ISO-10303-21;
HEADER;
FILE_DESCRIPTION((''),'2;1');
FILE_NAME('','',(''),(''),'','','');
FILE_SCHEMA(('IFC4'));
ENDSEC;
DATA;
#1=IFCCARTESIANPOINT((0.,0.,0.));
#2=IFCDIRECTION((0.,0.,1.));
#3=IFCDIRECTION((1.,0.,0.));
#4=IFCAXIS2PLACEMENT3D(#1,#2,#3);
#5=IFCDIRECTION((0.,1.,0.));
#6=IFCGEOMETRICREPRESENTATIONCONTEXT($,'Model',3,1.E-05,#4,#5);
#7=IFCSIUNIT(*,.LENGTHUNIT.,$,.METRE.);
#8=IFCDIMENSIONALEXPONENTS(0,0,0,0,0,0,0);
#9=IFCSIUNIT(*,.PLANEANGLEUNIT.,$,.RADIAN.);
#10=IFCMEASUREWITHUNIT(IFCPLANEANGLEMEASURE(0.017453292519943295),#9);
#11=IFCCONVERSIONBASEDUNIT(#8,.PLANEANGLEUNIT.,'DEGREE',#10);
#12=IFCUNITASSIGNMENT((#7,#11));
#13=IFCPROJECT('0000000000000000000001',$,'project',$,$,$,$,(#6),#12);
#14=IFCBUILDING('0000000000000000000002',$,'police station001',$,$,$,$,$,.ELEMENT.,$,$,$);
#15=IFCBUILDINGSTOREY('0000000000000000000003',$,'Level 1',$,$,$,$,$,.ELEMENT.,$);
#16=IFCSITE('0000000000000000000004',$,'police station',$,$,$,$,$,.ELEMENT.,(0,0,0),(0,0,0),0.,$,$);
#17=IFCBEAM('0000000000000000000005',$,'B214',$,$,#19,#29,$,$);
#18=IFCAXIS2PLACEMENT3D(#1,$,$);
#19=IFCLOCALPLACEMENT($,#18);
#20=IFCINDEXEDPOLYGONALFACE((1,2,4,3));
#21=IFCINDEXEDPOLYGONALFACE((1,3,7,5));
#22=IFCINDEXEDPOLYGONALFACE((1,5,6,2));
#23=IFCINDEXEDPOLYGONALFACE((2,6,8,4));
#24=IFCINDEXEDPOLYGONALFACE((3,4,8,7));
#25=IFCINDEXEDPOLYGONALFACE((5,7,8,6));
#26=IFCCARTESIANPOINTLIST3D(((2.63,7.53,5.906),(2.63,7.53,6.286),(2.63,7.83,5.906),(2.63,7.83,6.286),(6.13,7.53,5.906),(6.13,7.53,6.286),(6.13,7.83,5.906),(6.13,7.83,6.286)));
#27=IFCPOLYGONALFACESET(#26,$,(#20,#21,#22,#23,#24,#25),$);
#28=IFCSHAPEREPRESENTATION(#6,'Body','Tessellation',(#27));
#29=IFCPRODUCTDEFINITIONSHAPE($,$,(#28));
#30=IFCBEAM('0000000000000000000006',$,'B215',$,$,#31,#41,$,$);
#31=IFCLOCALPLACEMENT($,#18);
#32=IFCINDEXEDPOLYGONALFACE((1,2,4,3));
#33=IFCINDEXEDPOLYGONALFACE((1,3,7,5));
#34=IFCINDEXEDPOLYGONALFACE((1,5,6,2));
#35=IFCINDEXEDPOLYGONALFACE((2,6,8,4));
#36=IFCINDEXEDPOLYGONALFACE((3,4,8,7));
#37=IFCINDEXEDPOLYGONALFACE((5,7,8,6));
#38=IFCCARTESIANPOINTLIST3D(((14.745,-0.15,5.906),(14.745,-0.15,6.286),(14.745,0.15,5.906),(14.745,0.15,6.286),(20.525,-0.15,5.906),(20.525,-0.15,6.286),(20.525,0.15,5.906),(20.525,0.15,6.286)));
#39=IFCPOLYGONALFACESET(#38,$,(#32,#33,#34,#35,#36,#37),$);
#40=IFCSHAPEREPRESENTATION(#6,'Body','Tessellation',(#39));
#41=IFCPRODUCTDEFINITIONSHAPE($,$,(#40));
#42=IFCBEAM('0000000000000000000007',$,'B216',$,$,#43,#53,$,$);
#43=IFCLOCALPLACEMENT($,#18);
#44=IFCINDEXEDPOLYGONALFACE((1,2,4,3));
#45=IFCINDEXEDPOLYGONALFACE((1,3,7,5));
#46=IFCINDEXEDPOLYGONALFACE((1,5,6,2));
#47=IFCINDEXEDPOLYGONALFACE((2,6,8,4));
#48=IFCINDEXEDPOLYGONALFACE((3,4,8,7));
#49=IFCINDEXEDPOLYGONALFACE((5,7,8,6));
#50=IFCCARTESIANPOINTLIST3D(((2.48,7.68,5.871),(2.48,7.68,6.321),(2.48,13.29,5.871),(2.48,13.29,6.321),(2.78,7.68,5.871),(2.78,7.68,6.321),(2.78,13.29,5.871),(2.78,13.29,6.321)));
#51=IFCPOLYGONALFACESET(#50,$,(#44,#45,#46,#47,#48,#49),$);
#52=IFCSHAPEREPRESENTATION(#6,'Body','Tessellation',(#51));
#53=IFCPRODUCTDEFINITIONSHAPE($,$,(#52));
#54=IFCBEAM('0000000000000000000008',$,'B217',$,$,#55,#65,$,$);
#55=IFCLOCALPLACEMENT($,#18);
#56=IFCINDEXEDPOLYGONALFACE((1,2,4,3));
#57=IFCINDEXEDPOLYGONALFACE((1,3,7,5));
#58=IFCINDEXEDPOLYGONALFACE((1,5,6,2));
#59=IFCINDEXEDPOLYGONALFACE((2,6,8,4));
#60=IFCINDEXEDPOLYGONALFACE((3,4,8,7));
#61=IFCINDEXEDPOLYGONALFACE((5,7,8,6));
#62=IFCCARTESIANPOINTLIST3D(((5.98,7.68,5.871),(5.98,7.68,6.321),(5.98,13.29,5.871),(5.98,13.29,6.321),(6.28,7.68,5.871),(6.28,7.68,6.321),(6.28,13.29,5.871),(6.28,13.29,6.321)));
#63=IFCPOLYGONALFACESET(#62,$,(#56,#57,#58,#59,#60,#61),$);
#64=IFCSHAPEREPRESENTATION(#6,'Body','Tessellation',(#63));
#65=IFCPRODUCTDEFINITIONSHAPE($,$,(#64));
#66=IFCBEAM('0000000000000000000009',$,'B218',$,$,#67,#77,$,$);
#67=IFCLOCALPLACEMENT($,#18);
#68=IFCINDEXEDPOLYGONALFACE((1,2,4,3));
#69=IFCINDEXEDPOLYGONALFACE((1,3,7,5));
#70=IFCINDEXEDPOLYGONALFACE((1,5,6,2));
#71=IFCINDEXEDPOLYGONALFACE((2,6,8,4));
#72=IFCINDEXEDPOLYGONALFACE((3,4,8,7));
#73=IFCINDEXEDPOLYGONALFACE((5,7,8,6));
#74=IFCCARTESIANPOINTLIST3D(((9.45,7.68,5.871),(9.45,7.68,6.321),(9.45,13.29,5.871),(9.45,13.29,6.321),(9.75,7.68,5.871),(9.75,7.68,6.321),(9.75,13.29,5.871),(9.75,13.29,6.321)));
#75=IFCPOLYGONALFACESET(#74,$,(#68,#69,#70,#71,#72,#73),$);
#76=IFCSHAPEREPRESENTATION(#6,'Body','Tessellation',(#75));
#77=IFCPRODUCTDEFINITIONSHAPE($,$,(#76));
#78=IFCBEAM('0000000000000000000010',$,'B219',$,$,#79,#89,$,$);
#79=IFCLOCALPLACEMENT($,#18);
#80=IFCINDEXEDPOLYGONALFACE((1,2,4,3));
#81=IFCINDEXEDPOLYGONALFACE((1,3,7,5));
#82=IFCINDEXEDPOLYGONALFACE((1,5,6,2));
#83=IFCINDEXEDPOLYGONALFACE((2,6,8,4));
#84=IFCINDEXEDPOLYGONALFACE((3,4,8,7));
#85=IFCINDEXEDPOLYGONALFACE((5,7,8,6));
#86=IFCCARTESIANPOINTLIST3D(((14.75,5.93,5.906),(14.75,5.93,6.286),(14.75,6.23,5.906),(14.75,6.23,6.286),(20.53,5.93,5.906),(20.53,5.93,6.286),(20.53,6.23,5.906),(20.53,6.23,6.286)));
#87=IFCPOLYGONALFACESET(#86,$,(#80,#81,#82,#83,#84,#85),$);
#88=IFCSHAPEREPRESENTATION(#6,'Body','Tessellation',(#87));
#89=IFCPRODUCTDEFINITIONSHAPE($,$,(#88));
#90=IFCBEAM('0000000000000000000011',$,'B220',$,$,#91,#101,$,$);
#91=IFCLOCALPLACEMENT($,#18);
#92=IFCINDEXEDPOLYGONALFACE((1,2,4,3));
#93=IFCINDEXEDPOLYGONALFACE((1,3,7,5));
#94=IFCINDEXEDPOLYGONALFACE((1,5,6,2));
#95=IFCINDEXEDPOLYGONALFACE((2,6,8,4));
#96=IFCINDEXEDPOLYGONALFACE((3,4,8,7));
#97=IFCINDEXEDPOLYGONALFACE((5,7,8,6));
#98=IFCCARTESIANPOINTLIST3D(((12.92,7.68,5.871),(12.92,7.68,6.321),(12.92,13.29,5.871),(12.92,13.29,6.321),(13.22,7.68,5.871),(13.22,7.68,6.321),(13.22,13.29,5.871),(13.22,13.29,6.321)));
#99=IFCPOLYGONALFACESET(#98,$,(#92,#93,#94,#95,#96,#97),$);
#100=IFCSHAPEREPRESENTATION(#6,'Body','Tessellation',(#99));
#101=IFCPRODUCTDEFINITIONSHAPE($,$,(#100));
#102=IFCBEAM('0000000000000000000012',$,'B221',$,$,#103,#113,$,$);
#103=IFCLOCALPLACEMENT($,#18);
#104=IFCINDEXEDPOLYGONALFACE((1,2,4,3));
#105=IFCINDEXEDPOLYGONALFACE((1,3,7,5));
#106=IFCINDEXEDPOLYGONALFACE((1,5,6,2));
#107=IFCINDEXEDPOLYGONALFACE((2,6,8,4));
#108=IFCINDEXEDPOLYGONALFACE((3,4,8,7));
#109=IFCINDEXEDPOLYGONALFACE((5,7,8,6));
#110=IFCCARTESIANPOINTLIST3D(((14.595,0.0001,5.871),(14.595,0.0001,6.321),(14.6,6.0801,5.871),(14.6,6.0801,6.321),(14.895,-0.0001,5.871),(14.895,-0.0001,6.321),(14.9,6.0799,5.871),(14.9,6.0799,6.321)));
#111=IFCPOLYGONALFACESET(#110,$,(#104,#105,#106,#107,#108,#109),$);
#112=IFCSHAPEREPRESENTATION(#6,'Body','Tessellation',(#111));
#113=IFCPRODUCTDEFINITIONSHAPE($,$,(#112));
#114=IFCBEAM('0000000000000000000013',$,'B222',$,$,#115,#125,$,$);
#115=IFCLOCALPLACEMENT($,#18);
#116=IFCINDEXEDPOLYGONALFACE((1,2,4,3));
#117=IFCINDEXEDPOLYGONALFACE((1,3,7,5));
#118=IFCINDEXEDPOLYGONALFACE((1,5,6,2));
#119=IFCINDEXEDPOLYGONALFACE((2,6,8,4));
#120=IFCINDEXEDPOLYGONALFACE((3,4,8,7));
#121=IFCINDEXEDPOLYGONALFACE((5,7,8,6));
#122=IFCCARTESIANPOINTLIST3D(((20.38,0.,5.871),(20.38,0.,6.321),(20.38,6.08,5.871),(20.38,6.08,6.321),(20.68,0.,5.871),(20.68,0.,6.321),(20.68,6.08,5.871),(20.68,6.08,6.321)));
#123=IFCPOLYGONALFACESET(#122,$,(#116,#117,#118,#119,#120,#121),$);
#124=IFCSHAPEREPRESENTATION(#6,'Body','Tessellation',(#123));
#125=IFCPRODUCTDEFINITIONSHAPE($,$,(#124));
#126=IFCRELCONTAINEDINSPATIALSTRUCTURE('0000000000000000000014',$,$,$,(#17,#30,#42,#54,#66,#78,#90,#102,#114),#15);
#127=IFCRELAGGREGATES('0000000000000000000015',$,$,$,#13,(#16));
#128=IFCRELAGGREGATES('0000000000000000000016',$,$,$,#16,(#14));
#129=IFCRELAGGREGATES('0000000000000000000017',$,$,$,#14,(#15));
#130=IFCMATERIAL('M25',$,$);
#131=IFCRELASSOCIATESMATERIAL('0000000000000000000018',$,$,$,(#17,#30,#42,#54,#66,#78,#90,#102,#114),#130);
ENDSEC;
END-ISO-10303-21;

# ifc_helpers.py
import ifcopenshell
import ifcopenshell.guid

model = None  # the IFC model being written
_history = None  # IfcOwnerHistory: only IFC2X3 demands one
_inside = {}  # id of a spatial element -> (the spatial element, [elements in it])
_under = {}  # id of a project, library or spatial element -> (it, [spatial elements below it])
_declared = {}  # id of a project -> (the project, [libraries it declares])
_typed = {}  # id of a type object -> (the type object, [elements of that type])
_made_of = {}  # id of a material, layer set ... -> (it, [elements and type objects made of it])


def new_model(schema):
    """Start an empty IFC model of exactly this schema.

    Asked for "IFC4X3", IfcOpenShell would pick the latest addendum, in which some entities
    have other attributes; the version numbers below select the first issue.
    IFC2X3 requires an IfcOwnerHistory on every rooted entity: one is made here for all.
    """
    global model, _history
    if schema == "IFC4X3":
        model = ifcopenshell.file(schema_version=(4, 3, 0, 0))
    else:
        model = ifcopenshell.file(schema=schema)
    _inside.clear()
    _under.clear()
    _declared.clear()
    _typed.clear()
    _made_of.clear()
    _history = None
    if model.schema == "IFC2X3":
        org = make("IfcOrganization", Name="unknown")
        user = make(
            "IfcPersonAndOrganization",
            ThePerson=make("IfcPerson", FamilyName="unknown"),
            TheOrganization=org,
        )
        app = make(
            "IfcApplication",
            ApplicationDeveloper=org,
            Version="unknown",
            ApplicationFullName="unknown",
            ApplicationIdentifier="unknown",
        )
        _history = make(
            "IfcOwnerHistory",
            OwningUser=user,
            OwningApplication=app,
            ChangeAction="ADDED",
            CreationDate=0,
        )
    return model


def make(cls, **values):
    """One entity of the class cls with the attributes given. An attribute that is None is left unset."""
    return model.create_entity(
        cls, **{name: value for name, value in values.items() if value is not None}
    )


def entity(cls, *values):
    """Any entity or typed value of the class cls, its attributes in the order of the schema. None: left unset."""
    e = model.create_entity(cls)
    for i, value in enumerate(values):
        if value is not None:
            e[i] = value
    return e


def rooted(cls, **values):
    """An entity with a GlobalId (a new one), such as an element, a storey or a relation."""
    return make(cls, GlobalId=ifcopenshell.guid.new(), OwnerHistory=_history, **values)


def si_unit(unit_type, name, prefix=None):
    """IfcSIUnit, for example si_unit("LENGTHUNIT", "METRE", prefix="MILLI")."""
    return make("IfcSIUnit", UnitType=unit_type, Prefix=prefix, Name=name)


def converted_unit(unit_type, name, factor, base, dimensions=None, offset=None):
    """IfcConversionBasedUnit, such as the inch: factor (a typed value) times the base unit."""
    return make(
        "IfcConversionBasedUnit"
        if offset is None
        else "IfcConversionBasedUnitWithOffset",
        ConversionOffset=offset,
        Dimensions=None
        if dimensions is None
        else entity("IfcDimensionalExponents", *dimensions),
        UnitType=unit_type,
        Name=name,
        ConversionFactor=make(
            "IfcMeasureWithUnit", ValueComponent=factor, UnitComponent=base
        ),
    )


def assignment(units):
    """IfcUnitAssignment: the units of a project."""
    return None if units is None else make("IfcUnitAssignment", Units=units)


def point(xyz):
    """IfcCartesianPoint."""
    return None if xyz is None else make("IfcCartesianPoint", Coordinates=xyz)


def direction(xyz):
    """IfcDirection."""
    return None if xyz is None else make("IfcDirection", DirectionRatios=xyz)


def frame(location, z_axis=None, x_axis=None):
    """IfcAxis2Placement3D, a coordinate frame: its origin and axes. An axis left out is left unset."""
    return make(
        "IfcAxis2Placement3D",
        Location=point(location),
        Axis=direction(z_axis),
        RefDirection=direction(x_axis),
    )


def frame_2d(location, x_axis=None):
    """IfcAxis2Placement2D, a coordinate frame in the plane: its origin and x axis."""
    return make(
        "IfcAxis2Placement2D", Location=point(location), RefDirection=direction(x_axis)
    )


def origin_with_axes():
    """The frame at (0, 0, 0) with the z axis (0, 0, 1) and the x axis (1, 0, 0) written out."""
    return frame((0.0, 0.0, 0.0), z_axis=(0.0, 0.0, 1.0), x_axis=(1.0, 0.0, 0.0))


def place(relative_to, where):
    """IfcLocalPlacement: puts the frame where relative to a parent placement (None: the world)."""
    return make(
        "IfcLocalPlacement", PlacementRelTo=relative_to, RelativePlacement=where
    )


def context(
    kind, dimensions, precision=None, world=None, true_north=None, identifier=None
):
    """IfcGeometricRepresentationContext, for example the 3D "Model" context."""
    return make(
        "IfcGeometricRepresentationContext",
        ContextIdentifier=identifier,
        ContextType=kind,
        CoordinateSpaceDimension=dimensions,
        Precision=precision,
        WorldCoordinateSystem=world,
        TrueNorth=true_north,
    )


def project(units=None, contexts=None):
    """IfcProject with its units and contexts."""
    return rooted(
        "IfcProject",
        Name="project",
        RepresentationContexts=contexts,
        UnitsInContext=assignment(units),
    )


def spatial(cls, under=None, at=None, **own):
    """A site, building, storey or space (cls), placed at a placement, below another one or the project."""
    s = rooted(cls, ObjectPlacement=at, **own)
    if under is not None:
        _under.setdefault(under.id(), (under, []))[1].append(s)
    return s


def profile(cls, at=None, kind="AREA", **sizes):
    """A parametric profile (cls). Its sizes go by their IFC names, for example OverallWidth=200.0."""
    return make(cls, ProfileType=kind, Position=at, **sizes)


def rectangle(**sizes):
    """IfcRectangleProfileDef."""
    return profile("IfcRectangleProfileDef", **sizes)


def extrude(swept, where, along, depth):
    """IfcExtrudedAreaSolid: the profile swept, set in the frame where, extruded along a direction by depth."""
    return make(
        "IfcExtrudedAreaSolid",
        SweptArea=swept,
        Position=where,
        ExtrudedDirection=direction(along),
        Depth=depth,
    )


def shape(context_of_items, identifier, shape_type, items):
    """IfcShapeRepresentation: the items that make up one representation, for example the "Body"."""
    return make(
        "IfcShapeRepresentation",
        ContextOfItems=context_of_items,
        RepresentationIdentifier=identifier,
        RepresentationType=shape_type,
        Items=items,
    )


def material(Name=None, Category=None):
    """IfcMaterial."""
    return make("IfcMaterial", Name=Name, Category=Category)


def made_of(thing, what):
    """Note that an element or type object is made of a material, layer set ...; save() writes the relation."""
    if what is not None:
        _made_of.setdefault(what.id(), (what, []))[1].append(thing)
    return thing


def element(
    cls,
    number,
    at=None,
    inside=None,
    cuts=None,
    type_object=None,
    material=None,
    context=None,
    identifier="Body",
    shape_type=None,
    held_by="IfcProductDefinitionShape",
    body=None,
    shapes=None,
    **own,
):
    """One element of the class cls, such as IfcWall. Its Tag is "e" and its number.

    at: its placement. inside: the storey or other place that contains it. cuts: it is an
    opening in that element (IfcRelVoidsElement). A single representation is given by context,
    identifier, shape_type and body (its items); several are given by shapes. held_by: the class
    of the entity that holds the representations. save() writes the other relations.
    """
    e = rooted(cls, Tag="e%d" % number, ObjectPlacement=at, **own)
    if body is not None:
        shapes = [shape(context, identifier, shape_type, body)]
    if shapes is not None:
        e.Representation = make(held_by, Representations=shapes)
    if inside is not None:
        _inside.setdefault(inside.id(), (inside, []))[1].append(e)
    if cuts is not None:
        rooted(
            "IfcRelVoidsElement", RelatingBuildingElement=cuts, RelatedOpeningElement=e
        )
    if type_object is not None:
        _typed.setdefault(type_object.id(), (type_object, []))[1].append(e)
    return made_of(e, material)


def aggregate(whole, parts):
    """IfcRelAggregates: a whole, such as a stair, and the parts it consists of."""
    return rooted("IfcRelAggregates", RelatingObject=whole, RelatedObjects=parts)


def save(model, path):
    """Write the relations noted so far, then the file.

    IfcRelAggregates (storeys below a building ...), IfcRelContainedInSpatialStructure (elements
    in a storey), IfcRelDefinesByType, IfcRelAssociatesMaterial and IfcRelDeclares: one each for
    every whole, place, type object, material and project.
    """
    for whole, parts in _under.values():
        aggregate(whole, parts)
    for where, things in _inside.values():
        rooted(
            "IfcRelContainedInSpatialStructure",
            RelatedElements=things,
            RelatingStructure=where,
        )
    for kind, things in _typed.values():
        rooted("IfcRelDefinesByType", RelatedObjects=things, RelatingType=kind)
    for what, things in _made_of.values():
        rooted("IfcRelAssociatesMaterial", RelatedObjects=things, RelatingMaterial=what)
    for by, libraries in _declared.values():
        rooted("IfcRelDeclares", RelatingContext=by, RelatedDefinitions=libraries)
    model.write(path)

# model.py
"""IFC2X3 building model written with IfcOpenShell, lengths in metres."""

from ifc_helpers import new_model, entity, si_unit, converted_unit, direction, frame, frame_2d, origin_with_axes, place, context, project, spatial, rectangle, extrude, material, element, save


model = new_model("IFC2X3")

# Units and contexts
model_context = context("Model", 3, precision=1e-05, world=origin_with_axes(), true_north=direction((0.0, 1.0, 0.0)))
ifc_project = project(units=[si_unit("LENGTHUNIT", "METRE"), converted_unit("PLANEANGLEUNIT", "DEGREE", entity("IfcPlaneAngleMeasure", 0.017453292519943295), si_unit("PLANEANGLEUNIT", "RADIAN"), dimensions=[0, 0, 0, 0, 0, 0, 0])], contexts=[model_context])

# Site, building, storey
site = spatial("IfcSite", under=ifc_project, Name="police station", CompositionType="ELEMENT", RefLatitude=(0, 0, 0), RefLongitude=(0, 0, 0), RefElevation=0.0)
building = spatial("IfcBuilding", under=site, Name="police station001", CompositionType="ELEMENT")
storey = spatial("IfcBuildingStorey", under=building, Name="Level 1", CompositionType="ELEMENT")

# Shared definitions
ifc_material = material(Name="M25")
placement = place(None, origin_with_axes())

# Beams
element("IfcBeam", 1, at=placement, inside=storey, material=ifc_material, Name="B214", context=model_context, shape_type="SweptSolid", body=[
    extrude(rectangle(XDim=0.3, YDim=0.38, at=frame_2d((0.0, 0.0), x_axis=(0.0, 1.0, 0.0))), frame((2.63, 7.68, 6.096), z_axis=(1.0, 0.0, 0.0), x_axis=(0.0, 0.0, -1.0)), (0.0, 0.0, 1.0), 3.5),
])
element("IfcBeam", 2, at=placement, inside=storey, material=ifc_material, Name="B215", context=model_context, shape_type="SweptSolid", body=[
    extrude(rectangle(XDim=0.3, YDim=0.38, at=frame_2d((0.0, 0.0), x_axis=(0.0, 1.0, 0.0))), frame((14.745, 0.0, 6.096), z_axis=(1.0, 0.0, 0.0), x_axis=(0.0, 0.0, -1.0)), (0.0, 0.0, 1.0), 5.78),
])
element("IfcBeam", 3, at=placement, inside=storey, material=ifc_material, Name="B216", context=model_context, shape_type="SweptSolid", body=[
    extrude(rectangle(XDim=0.3, YDim=0.45, at=frame_2d((0.0, 0.0), x_axis=(0.0, 1.0, 0.0))), frame((2.63, 13.29, 6.096), z_axis=(0.0, -1.0, 0.0), x_axis=(0.0, 0.0, -1.0)), (0.0, 0.0, 1.0), 5.61),
])
element("IfcBeam", 4, at=placement, inside=storey, material=ifc_material, Name="B217", context=model_context, shape_type="SweptSolid", body=[
    extrude(rectangle(XDim=0.3, YDim=0.45, at=frame_2d((0.0, 0.0), x_axis=(0.0, 1.0, 0.0))), frame((6.13, 7.68, 6.096), z_axis=(0.0, 1.0, 0.0), x_axis=(0.0, 0.0, -1.0)), (0.0, 0.0, 1.0), 5.61),
])
element("IfcBeam", 5, at=placement, inside=storey, material=ifc_material, Name="B218", context=model_context, shape_type="SweptSolid", body=[
    extrude(rectangle(XDim=0.3, YDim=0.45, at=frame_2d((0.0, 0.0), x_axis=(0.0, 1.0, 0.0))), frame((9.6, 7.68, 6.096), z_axis=(0.0, 1.0, 0.0), x_axis=(0.0, 0.0, -1.0)), (0.0, 0.0, 1.0), 5.61),
])
element("IfcBeam", 6, at=placement, inside=storey, material=ifc_material, Name="B219", context=model_context, shape_type="SweptSolid", body=[
    extrude(rectangle(XDim=0.3, YDim=0.38, at=frame_2d((0.0, 0.0), x_axis=(0.0, 1.0, 0.0))), frame((20.53, 6.08, 6.096), z_axis=(-1.0, 0.0, 0.0), x_axis=(0.0, 0.0, -1.0)), (0.0, 0.0, 1.0), 5.78),
])
element("IfcBeam", 7, at=placement, inside=storey, material=ifc_material, Name="B220", context=model_context, shape_type="SweptSolid", body=[
    extrude(rectangle(XDim=0.3, YDim=0.45, at=frame_2d((0.0, 0.0), x_axis=(0.0, 1.0, 0.0))), frame((13.07, 13.29, 6.096), z_axis=(0.0, -1.0, 0.0), x_axis=(0.0, 0.0, -1.0)), (0.0, 0.0, 1.0), 5.61),
])
element("IfcBeam", 8, at=placement, inside=storey, material=ifc_material, Name="B221", context=model_context, shape_type="SweptSolid", body=[
    extrude(rectangle(XDim=0.3, YDim=0.45, at=frame_2d((0.0, 0.0), x_axis=(0.0, 1.0, 0.0))), frame((14.745, 0.0, 6.096), z_axis=(0.000822, 1.0, 0.0), x_axis=(0.0, 0.0, -1.0)), (0.0, 0.0, 1.0), 6.08),
])
element("IfcBeam", 9, at=placement, inside=storey, material=ifc_material, Name="B222", context=model_context, shape_type="SweptSolid", body=[
    extrude(rectangle(XDim=0.3, YDim=0.45, at=frame_2d((0.0, 0.0), x_axis=(0.0, 1.0, 0.0))), frame((20.53, 0.0, 6.096), z_axis=(0.0, 1.0, 0.0), x_axis=(0.0, 0.0, -1.0)), (0.0, 0.0, 1.0), 6.08),
])

save(model, "model.ifc")
